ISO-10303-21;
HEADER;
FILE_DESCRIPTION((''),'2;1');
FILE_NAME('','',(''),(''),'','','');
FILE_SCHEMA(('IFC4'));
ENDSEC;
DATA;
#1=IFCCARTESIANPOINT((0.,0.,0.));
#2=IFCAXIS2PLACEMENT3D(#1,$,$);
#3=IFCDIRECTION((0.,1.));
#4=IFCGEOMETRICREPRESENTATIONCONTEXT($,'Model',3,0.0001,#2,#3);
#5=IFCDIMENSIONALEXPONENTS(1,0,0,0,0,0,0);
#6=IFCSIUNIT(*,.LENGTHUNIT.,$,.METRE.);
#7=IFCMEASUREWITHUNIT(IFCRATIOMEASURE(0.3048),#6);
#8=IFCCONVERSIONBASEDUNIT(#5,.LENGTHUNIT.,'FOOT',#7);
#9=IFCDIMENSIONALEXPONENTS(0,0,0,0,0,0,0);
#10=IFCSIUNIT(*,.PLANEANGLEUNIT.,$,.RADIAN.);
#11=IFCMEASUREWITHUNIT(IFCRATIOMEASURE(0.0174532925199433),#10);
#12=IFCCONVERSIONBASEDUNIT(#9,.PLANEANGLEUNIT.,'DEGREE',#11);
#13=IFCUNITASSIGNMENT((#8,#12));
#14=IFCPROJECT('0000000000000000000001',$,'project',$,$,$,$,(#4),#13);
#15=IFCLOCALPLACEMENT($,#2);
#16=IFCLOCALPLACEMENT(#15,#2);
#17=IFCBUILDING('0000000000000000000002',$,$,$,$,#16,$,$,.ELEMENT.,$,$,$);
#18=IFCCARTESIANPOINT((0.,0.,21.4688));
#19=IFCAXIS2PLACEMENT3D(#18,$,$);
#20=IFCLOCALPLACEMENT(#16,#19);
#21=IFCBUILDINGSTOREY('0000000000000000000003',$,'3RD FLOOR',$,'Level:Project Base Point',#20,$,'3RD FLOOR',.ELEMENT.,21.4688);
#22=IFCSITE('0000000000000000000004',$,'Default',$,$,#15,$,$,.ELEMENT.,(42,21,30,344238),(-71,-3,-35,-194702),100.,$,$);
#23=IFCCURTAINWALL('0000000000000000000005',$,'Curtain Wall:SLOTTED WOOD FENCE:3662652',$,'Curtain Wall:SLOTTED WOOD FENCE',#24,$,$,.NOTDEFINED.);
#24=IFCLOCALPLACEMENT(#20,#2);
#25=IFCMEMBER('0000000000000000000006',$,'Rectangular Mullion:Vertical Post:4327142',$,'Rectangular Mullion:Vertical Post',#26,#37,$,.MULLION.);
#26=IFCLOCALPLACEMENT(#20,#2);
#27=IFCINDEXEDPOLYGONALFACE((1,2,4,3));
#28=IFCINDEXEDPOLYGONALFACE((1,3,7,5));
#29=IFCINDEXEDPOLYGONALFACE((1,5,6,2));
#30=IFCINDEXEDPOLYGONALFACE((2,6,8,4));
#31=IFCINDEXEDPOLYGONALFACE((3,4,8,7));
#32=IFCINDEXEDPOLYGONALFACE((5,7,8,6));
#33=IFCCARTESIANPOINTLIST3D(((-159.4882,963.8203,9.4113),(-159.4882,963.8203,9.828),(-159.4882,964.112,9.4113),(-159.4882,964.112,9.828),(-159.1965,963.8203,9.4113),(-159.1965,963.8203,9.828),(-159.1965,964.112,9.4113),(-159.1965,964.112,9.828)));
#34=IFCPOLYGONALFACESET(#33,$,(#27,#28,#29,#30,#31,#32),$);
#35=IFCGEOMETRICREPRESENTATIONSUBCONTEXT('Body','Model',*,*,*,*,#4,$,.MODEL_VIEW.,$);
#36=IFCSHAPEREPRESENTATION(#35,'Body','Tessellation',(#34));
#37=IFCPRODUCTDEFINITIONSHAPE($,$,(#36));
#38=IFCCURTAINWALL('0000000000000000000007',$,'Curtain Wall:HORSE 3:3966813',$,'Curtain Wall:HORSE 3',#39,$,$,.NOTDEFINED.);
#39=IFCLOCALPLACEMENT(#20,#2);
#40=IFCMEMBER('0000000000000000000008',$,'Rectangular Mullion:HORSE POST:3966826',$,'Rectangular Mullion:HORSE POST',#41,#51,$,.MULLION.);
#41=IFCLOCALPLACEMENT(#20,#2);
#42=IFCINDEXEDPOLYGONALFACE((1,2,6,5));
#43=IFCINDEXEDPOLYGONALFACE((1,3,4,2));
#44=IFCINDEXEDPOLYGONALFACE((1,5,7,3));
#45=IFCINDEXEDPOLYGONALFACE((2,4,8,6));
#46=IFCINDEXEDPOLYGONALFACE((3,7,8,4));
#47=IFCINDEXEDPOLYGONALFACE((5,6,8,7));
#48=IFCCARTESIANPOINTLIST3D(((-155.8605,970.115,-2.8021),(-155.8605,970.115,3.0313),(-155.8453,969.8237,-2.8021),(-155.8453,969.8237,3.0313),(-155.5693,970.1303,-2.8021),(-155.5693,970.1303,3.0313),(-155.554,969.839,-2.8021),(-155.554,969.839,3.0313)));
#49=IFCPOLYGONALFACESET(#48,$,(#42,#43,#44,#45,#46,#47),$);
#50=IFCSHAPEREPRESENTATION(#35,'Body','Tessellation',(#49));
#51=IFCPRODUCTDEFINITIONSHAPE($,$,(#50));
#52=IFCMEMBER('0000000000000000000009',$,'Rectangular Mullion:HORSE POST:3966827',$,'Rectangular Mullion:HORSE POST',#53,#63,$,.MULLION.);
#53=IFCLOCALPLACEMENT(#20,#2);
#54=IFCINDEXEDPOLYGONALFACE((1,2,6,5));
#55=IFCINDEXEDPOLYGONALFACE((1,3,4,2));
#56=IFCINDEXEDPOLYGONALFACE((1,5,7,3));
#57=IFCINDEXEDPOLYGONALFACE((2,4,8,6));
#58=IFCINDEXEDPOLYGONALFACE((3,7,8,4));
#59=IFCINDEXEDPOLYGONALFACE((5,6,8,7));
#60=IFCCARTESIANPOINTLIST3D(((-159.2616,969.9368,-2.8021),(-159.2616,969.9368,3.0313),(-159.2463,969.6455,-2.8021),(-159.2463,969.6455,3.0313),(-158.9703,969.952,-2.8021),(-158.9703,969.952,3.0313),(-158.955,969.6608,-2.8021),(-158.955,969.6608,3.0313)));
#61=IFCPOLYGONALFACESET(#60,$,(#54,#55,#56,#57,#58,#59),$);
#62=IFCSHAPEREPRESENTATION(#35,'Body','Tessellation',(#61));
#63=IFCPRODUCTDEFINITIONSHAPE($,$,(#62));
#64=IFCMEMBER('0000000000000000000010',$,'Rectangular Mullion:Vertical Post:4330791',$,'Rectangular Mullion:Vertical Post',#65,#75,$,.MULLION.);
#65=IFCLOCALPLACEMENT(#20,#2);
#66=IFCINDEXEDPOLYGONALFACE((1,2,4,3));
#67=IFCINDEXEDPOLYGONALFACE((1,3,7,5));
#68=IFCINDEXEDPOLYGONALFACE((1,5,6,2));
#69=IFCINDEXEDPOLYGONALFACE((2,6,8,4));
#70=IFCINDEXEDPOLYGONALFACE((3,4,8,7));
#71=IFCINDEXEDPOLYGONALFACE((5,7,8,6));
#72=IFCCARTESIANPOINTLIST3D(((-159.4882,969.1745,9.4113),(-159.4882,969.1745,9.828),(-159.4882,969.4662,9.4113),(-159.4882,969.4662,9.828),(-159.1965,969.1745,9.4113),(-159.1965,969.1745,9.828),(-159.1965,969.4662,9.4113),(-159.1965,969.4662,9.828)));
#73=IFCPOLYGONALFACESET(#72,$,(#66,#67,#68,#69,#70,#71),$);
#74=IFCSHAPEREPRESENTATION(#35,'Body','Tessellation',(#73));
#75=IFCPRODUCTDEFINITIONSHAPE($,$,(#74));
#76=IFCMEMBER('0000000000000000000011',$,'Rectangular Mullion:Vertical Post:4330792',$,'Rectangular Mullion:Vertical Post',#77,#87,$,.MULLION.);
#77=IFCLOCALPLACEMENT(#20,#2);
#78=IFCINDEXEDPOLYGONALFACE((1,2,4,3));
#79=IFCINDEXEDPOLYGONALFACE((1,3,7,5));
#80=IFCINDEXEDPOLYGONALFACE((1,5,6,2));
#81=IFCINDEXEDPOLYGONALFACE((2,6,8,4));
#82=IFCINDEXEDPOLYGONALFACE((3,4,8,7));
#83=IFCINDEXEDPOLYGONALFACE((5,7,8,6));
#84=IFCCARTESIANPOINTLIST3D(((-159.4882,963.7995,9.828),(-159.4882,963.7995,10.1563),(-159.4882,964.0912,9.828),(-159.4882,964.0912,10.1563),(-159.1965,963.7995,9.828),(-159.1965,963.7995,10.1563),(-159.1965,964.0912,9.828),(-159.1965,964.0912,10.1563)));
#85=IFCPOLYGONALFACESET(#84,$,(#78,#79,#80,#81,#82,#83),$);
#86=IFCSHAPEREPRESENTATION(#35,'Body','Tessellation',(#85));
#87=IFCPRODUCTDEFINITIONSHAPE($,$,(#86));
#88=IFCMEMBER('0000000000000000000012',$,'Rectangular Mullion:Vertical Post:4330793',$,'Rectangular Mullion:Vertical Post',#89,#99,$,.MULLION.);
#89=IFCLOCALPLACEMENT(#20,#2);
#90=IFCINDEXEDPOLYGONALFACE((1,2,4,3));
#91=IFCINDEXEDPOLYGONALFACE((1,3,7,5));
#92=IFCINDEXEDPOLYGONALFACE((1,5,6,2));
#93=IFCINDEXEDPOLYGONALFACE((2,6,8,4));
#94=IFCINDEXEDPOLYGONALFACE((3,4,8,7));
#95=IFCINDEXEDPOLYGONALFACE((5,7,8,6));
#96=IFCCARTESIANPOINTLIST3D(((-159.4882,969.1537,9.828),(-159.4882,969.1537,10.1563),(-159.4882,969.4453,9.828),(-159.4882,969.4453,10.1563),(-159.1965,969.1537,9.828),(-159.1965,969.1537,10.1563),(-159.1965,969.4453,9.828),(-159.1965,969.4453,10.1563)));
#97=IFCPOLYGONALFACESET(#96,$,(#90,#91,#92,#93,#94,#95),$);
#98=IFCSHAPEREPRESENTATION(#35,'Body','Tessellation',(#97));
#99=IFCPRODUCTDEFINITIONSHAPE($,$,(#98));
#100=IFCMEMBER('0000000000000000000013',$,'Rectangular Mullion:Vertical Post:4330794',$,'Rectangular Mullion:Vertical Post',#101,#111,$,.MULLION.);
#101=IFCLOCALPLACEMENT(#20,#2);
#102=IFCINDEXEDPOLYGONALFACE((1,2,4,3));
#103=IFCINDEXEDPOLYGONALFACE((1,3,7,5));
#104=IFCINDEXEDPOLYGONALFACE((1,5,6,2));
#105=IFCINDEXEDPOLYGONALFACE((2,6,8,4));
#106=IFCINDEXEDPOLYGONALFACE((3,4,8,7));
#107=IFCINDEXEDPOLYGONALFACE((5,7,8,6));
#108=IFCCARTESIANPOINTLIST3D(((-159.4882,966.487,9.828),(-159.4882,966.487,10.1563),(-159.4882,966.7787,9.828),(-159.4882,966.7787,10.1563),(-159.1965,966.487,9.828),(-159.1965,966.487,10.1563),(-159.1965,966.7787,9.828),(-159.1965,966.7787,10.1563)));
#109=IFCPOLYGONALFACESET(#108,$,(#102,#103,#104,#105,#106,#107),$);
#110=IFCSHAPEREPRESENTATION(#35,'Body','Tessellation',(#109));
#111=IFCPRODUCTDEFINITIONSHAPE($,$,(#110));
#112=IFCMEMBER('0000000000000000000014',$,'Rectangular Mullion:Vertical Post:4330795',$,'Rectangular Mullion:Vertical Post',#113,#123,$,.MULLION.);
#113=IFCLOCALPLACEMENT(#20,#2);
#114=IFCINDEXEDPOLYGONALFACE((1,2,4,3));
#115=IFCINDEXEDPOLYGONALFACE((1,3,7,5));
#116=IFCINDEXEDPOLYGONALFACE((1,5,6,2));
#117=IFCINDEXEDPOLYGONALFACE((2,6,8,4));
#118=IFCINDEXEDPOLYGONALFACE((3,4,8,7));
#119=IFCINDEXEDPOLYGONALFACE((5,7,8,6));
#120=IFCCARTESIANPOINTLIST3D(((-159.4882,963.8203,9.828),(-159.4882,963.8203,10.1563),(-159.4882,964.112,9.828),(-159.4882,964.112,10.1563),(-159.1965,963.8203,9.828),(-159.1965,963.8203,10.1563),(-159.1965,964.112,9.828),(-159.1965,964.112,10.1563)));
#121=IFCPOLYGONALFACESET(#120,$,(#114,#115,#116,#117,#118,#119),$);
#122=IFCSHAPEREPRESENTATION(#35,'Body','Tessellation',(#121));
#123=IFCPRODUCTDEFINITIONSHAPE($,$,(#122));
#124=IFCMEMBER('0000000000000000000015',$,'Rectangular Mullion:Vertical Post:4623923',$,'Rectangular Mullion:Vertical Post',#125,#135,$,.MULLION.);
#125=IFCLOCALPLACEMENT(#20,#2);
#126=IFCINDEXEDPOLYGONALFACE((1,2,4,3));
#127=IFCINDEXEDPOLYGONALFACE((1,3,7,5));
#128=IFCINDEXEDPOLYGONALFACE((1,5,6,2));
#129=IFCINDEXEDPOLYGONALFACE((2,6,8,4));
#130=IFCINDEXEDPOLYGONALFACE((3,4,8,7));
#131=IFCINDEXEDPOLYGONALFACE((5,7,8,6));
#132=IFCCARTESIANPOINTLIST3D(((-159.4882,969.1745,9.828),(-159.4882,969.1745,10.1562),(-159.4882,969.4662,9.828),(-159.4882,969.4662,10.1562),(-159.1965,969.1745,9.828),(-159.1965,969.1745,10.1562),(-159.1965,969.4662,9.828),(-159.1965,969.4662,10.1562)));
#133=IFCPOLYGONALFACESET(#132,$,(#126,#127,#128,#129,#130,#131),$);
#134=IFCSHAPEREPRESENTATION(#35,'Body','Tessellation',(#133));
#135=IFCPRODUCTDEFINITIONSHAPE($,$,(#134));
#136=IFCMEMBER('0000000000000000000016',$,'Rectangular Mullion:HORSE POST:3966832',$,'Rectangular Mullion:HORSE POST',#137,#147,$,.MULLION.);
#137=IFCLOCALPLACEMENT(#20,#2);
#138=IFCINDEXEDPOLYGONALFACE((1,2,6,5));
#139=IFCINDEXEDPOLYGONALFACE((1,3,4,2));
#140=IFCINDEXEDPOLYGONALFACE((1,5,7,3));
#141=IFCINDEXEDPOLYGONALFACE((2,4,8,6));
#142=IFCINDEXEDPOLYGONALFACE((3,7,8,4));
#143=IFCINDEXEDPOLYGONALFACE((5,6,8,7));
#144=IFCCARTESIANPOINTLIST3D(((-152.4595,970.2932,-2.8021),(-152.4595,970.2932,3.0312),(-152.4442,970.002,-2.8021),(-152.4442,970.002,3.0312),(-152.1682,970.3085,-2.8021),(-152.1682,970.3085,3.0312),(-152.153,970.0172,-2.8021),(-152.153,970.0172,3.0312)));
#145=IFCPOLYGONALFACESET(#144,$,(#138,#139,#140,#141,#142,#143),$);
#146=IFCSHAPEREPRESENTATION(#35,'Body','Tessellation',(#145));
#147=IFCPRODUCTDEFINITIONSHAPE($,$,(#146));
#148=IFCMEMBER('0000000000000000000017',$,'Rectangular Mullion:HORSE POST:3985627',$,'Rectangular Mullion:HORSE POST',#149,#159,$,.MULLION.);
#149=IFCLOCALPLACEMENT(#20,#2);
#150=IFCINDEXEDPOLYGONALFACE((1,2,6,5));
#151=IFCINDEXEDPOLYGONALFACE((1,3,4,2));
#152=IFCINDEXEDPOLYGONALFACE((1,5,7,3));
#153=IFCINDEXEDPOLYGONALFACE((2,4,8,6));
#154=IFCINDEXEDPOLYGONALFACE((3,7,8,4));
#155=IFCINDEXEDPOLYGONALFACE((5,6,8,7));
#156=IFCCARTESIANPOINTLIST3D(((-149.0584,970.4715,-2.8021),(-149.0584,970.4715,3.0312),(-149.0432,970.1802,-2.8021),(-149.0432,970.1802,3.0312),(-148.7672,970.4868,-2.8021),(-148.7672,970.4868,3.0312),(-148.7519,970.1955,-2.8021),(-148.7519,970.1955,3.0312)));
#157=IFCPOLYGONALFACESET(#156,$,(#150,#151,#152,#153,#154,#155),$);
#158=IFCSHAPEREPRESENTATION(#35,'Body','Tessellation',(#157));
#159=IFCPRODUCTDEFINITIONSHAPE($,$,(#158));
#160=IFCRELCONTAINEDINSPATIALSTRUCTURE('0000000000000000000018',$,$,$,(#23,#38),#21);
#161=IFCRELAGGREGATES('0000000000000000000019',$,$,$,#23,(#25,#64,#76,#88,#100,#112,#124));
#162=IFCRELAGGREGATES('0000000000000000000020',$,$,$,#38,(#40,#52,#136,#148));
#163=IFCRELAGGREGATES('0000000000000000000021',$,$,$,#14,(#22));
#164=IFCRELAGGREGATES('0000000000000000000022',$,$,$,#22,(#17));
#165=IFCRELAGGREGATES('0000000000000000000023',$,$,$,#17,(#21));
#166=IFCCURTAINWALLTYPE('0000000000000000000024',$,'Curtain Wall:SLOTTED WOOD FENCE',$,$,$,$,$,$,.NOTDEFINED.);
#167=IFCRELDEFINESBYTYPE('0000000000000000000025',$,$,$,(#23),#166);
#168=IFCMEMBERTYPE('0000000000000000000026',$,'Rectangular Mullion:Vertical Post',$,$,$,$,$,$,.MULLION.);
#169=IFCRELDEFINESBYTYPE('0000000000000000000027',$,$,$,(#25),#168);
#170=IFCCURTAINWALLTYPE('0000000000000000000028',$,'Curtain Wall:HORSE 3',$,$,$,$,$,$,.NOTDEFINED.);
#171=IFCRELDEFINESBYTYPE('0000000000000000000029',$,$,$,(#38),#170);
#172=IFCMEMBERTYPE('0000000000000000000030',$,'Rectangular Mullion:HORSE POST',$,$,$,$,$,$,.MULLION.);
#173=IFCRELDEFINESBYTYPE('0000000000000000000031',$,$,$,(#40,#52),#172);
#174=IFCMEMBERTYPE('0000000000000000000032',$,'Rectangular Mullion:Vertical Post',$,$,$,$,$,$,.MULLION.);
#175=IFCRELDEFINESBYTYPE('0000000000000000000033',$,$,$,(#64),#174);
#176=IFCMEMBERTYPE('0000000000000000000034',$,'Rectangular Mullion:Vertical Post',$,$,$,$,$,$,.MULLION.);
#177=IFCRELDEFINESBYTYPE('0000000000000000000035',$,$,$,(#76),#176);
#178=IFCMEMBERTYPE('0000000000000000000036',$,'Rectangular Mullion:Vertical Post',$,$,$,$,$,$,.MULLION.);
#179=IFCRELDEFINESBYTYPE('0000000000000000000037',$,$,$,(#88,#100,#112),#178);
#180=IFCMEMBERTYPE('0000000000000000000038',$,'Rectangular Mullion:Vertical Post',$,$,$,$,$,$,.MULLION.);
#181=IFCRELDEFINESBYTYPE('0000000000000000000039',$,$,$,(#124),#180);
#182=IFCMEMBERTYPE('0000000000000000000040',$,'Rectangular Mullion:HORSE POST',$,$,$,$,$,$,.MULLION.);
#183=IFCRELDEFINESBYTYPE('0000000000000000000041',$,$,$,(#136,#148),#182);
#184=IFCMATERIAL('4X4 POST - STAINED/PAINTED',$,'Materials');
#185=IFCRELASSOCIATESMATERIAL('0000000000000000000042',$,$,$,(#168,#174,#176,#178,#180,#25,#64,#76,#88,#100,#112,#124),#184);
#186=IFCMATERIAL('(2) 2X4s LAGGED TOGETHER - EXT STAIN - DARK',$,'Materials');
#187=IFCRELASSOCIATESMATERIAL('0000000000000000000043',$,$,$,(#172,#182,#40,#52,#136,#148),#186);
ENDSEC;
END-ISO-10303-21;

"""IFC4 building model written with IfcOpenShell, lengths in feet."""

from ifc_helpers import new_model, entity, si_unit, converted_unit, direction, frame, frame_2d, origin, origin_2d_with_axis, place, context, subcontext, project, spatial, rectangle, extrude, source, transform, mapped, material, material_profile, profile_set, profile_usage, type_object, type_shapes, element, aggregate, save


model = new_model("IFC4")

# Units and contexts
model_context = context("Model", 3, precision=0.0001, world=origin(), true_north=direction((0.0, 1.0)))
body_context = subcontext(model_context, "Body", "Model", "MODEL_VIEW")
ifc_project = project(units=[converted_unit("LENGTHUNIT", "FOOT", entity("IfcRatioMeasure", 0.3048), si_unit("LENGTHUNIT", "METRE"), dimensions=[1, 0, 0, 0, 0, 0, 0]), converted_unit("PLANEANGLEUNIT", "DEGREE", entity("IfcRatioMeasure", 0.0174532925199433), si_unit("PLANEANGLEUNIT", "RADIAN"), dimensions=[0, 0, 0, 0, 0, 0, 0])], contexts=[model_context])

# Site, building, storey
site_placement = place(None, origin())
site = spatial("IfcSite", under=ifc_project, at=site_placement, Name="Default", CompositionType="ELEMENT", RefLatitude=(42, 21, 30, 344238), RefLongitude=(-71, -3, -35, -194702), RefElevation=100.0)
building_placement = place(site_placement, origin())
building = spatial("IfcBuilding", under=site, at=building_placement, CompositionType="ELEMENT")
storey_placement = place(building_placement, frame((0.0, 0.0, 21.4688)))
storey = spatial("IfcBuildingStorey", under=building, at=storey_placement, Name="3RD FLOOR", ObjectType="Level:Project Base Point", LongName="3RD FLOOR", CompositionType="ELEMENT", Elevation=21.4688)

# Curtain wall, member
curtain_wall_type_1 = type_object("IfcCurtainWallType", Name="Curtain Wall:SLOTTED WOOD FENCE", PredefinedType="NOTDEFINED")
curtain_wall_1_placement = place(storey_placement, frame((0.0, 0.0, -21.4688)))
curtain_wall_1 = element("IfcCurtainWall", 1, at=curtain_wall_1_placement, inside=storey, type_object=curtain_wall_type_1, Name="Curtain Wall:SLOTTED WOOD FENCE:3662652", ObjectType="Curtain Wall:SLOTTED WOOD FENCE", PredefinedType="NOTDEFINED")
ifc_material_1 = material(Name="4X4 POST - STAINED/PAINTED", Category="Materials")
ifc_material_profile_1 = material_profile(ifc_material_1, rectangle(XDim=0.2917, YDim=0.2917, at=origin_2d_with_axis()), Name="Vertical Post")
ifc_profile_set_1 = profile_set([ifc_material_profile_1], Name="Vertical Post")
ifc_profile_usage_1 = profile_usage(ifc_profile_set_1)
member_type_1 = type_object("IfcMemberType", Name="Rectangular Mullion:Vertical Post", PredefinedType="MULLION", material=ifc_profile_set_1)
shared_shape_1 = source(origin(), body_context, "Body", "SweptSolid", [
    extrude(rectangle(XDim=0.2917, YDim=0.2917, at=origin_2d_with_axis()), frame((0.0, -0.2083, -0.4167), z_axis=(0.0, 0.0, 1.0), x_axis=(0.0, -1.0, 0.0)), (0.0, 0.0, 1.0), 0.4167),
])
type_shapes(member_type_1, [shared_shape_1])
member_1_placement = place(storey_placement, frame((-159.5507, 963.9662, 9.4113), z_axis=(0.0, 0.0, -1.0), x_axis=(0.0, -1.0, 0.0)))
member_1 = element("IfcMember", 2, at=member_1_placement, type_object=member_type_1, material=ifc_profile_usage_1, Name="Rectangular Mullion:Vertical Post:4327142", ObjectType="Rectangular Mullion:Vertical Post", PredefinedType="MULLION", context=body_context, shape_type="MappedRepresentation", body=[
    mapped(shared_shape_1, transform((0.0, 0.0, 0.0), scale=1.0)),
])

# Curtain wall, members
curtain_wall_type_2 = type_object("IfcCurtainWallType", Name="Curtain Wall:HORSE 3", PredefinedType="NOTDEFINED")
curtain_wall_2_placement = place(storey_placement, frame((0.0, 0.0, -21.4688)))
curtain_wall_2 = element("IfcCurtainWall", 3, at=curtain_wall_2_placement, inside=storey, type_object=curtain_wall_type_2, Name="Curtain Wall:HORSE 3:3966813", ObjectType="Curtain Wall:HORSE 3", PredefinedType="NOTDEFINED")
ifc_material_2 = material(Name="(2) 2X4s LAGGED TOGETHER - EXT STAIN - DARK", Category="Materials")
ifc_material_profile_2 = material_profile(ifc_material_2, rectangle(XDim=0.2917, YDim=0.2917, at=frame_2d((0.0, 0.0), x_axis=(1.0, 0.0))), Name="HORSE POST")
ifc_profile_set_2 = profile_set([ifc_material_profile_2], Name="HORSE POST")
ifc_profile_usage_2 = profile_usage(ifc_profile_set_2)
member_type_2 = type_object("IfcMemberType", Name="Rectangular Mullion:HORSE POST", PredefinedType="MULLION", material=ifc_profile_set_2)
shared_shape_2 = source(origin(), body_context, "Body", "SweptSolid", [
    extrude(rectangle(XDim=0.2917, YDim=0.2917, at=origin_2d_with_axis()), frame((0.0, 0.1458, -5.8333), z_axis=(0.0, 0.0, 1.0), x_axis=(0.0, -1.0, 0.0)), (0.0, 0.0, 1.0), 5.8333),
])
type_shapes(member_type_2, [shared_shape_2])
member_2_placement = place(storey_placement, frame((-155.6996, 969.8314, -2.8021), z_axis=(0.0, 0.0, -1.0), x_axis=(-0.99863, -0.052336, 0.0)))
member_2 = element("IfcMember", 4, at=member_2_placement, type_object=member_type_2, material=ifc_profile_usage_2, Name="Rectangular Mullion:HORSE POST:3966826", ObjectType="Rectangular Mullion:HORSE POST", PredefinedType="MULLION", context=body_context, shape_type="MappedRepresentation", body=[
    mapped(shared_shape_2, transform((0.0, 0.0, 0.0), scale=1.0)),
])
ifc_profile_usage_3 = profile_usage(ifc_profile_set_2)
member_3_placement = place(storey_placement, frame((-159.1007, 969.6531, -2.8021), z_axis=(0.0, 0.0, -1.0), x_axis=(-0.99863, -0.052336, 0.0)))
member_3 = element("IfcMember", 5, at=member_3_placement, type_object=member_type_2, material=ifc_profile_usage_3, Name="Rectangular Mullion:HORSE POST:3966827", ObjectType="Rectangular Mullion:HORSE POST", PredefinedType="MULLION", context=body_context, shape_type="MappedRepresentation", body=[
    mapped(shared_shape_2, transform((0.0, 0.0, 0.0), scale=1.0)),
])

# Members
ifc_profile_usage_4 = profile_usage(ifc_profile_set_1)
member_type_3 = type_object("IfcMemberType", Name="Rectangular Mullion:Vertical Post", PredefinedType="MULLION", material=ifc_profile_set_1)
shared_shape_3 = source(origin(), body_context, "Body", "SweptSolid", [
    extrude(rectangle(XDim=0.2917, YDim=0.2917, at=origin_2d_with_axis()), frame((-0.1458, -0.2083, -0.4167), z_axis=(0.0, 0.0, 1.0), x_axis=(0.0, -1.0, 0.0)), (0.0, 0.0, 1.0), 0.4167),
])
type_shapes(member_type_3, [shared_shape_3])
member_4_placement = place(storey_placement, frame((-159.5507, 969.4662, 9.828), z_axis=(0.0, 0.0, 1.0), x_axis=(0.0, 1.0, 0.0)))
member_4 = element("IfcMember", 6, at=member_4_placement, type_object=member_type_3, material=ifc_profile_usage_4, Name="Rectangular Mullion:Vertical Post:4330791", ObjectType="Rectangular Mullion:Vertical Post", PredefinedType="MULLION", context=body_context, shape_type="MappedRepresentation", body=[
    mapped(shared_shape_3, transform((0.0, 0.0, 0.0), scale=1.0)),
])
ifc_profile_usage_5 = profile_usage(ifc_profile_set_1)
member_type_4 = type_object("IfcMemberType", Name="Rectangular Mullion:Vertical Post", PredefinedType="MULLION", material=ifc_profile_set_1)
shared_shape_4 = source(origin(), body_context, "Body", "SweptSolid", [
    extrude(rectangle(XDim=0.2917, YDim=0.2917, at=origin_2d_with_axis()), frame((-0.1458, -0.2083, -0.3282), z_axis=(0.0, 0.0, 1.0), x_axis=(0.0, -1.0, 0.0)), (0.0, 0.0, 1.0), 0.3282),
])
type_shapes(member_type_4, [shared_shape_4])
member_5_placement = place(storey_placement, frame((-159.5507, 963.7995, 9.828), z_axis=(0.0, 0.0, -1.0), x_axis=(0.0, -1.0, 0.0)))
member_5 = element("IfcMember", 7, at=member_5_placement, type_object=member_type_4, material=ifc_profile_usage_5, Name="Rectangular Mullion:Vertical Post:4330792", ObjectType="Rectangular Mullion:Vertical Post", PredefinedType="MULLION", context=body_context, shape_type="MappedRepresentation", body=[
    mapped(shared_shape_4, transform((0.0, 0.0, 0.0), scale=1.0)),
])
ifc_profile_usage_6 = profile_usage(ifc_profile_set_1)
member_type_5 = type_object("IfcMemberType", Name="Rectangular Mullion:Vertical Post", PredefinedType="MULLION", material=ifc_profile_set_1)
shared_shape_5 = source(origin(), body_context, "Body", "SweptSolid", [
    extrude(rectangle(XDim=0.2917, YDim=0.2917, at=origin_2d_with_axis()), frame((0.0, -0.2083, -0.3282), z_axis=(0.0, 0.0, 1.0), x_axis=(0.0, -1.0, 0.0)), (0.0, 0.0, 1.0), 0.3282),
])
type_shapes(member_type_5, [shared_shape_5])
member_6_placement = place(storey_placement, frame((-159.5507, 969.2995, 9.828), z_axis=(0.0, 0.0, -1.0), x_axis=(0.0, -1.0, 0.0)))
member_6 = element("IfcMember", 8, at=member_6_placement, type_object=member_type_5, material=ifc_profile_usage_6, Name="Rectangular Mullion:Vertical Post:4330793", ObjectType="Rectangular Mullion:Vertical Post", PredefinedType="MULLION", context=body_context, shape_type="MappedRepresentation", body=[
    mapped(shared_shape_5, transform((0.0, 0.0, 0.0), scale=1.0)),
])
ifc_profile_usage_7 = profile_usage(ifc_profile_set_1)
member_7_placement = place(storey_placement, frame((-159.5507, 966.6328, 9.828), z_axis=(0.0, 0.0, -1.0), x_axis=(0.0, -1.0, 0.0)))
member_7 = element("IfcMember", 9, at=member_7_placement, type_object=member_type_5, material=ifc_profile_usage_7, Name="Rectangular Mullion:Vertical Post:4330794", ObjectType="Rectangular Mullion:Vertical Post", PredefinedType="MULLION", context=body_context, shape_type="MappedRepresentation", body=[
    mapped(shared_shape_5, transform((0.0, 0.0, 0.0), scale=1.0)),
])
ifc_profile_usage_8 = profile_usage(ifc_profile_set_1)
member_8_placement = place(storey_placement, frame((-159.5507, 963.9662, 9.828), z_axis=(0.0, 0.0, -1.0), x_axis=(0.0, -1.0, 0.0)))
member_8 = element("IfcMember", 10, at=member_8_placement, type_object=member_type_5, material=ifc_profile_usage_8, Name="Rectangular Mullion:Vertical Post:4330795", ObjectType="Rectangular Mullion:Vertical Post", PredefinedType="MULLION", context=body_context, shape_type="MappedRepresentation", body=[
    mapped(shared_shape_5, transform((0.0, 0.0, 0.0), scale=1.0)),
])
ifc_profile_usage_9 = profile_usage(ifc_profile_set_1)
member_type_6 = type_object("IfcMemberType", Name="Rectangular Mullion:Vertical Post", PredefinedType="MULLION", material=ifc_profile_set_1)
shared_shape_6 = source(origin(), body_context, "Body", "SweptSolid", [
    extrude(rectangle(XDim=0.2917, YDim=0.2917, at=origin_2d_with_axis()), frame((-0.1458, -0.2083, -0.3282), z_axis=(0.0, 0.0, 1.0), x_axis=(0.0, -1.0, 0.0)), (0.0, 0.0, 1.0), 0.3282),
])
type_shapes(member_type_6, [shared_shape_6])
member_9_placement = place(storey_placement, frame((-159.5507, 969.4662, 10.1562), z_axis=(0.0, 0.0, 1.0), x_axis=(0.0, 1.0, 0.0)))
member_9 = element("IfcMember", 11, at=member_9_placement, type_object=member_type_6, material=ifc_profile_usage_9, Name="Rectangular Mullion:Vertical Post:4623923", ObjectType="Rectangular Mullion:Vertical Post", PredefinedType="MULLION", context=body_context, shape_type="MappedRepresentation", body=[
    mapped(shared_shape_6, transform((0.0, 0.0, 0.0), scale=1.0)),
])
aggregate(curtain_wall_1, [member_1, member_4, member_5, member_6, member_7, member_8, member_9])
ifc_profile_usage_10 = profile_usage(ifc_profile_set_2)
member_type_7 = type_object("IfcMemberType", Name="Rectangular Mullion:HORSE POST", PredefinedType="MULLION", material=ifc_profile_set_2)
shared_shape_7 = source(origin(), body_context, "Body", "SweptSolid", [
    extrude(rectangle(XDim=0.2917, YDim=0.2917, at=origin_2d_with_axis()), frame((0.0, 0.1458, -5.8333), z_axis=(0.0, 0.0, 1.0), x_axis=(0.0, -1.0, 0.0)), (0.0, 0.0, 1.0), 5.8333),
])
type_shapes(member_type_7, [shared_shape_7])
member_10_placement = place(storey_placement, frame((-152.2986, 970.0096, -2.8021), z_axis=(0.0, 0.0, -1.0), x_axis=(-0.99863, -0.052336, 0.0)))
member_10 = element("IfcMember", 12, at=member_10_placement, type_object=member_type_7, material=ifc_profile_usage_10, Name="Rectangular Mullion:HORSE POST:3966832", ObjectType="Rectangular Mullion:HORSE POST", PredefinedType="MULLION", context=body_context, shape_type="MappedRepresentation", body=[
    mapped(shared_shape_7, transform((0.0, 0.0, 0.0), scale=1.0)),
])
ifc_profile_usage_11 = profile_usage(ifc_profile_set_2)
member_11_placement = place(storey_placement, frame((-148.8975, 970.1879, -2.8021), z_axis=(0.0, 0.0, -1.0), x_axis=(-0.99863, -0.052336, 0.0)))
member_11 = element("IfcMember", 13, at=member_11_placement, type_object=member_type_7, material=ifc_profile_usage_11, Name="Rectangular Mullion:HORSE POST:3985627", ObjectType="Rectangular Mullion:HORSE POST", PredefinedType="MULLION", context=body_context, shape_type="MappedRepresentation", body=[
    mapped(shared_shape_7, transform((0.0, 0.0, 0.0), scale=1.0)),
])

aggregate(curtain_wall_2, [member_2, member_3, member_10, member_11])

save(model, "model.ifc")
